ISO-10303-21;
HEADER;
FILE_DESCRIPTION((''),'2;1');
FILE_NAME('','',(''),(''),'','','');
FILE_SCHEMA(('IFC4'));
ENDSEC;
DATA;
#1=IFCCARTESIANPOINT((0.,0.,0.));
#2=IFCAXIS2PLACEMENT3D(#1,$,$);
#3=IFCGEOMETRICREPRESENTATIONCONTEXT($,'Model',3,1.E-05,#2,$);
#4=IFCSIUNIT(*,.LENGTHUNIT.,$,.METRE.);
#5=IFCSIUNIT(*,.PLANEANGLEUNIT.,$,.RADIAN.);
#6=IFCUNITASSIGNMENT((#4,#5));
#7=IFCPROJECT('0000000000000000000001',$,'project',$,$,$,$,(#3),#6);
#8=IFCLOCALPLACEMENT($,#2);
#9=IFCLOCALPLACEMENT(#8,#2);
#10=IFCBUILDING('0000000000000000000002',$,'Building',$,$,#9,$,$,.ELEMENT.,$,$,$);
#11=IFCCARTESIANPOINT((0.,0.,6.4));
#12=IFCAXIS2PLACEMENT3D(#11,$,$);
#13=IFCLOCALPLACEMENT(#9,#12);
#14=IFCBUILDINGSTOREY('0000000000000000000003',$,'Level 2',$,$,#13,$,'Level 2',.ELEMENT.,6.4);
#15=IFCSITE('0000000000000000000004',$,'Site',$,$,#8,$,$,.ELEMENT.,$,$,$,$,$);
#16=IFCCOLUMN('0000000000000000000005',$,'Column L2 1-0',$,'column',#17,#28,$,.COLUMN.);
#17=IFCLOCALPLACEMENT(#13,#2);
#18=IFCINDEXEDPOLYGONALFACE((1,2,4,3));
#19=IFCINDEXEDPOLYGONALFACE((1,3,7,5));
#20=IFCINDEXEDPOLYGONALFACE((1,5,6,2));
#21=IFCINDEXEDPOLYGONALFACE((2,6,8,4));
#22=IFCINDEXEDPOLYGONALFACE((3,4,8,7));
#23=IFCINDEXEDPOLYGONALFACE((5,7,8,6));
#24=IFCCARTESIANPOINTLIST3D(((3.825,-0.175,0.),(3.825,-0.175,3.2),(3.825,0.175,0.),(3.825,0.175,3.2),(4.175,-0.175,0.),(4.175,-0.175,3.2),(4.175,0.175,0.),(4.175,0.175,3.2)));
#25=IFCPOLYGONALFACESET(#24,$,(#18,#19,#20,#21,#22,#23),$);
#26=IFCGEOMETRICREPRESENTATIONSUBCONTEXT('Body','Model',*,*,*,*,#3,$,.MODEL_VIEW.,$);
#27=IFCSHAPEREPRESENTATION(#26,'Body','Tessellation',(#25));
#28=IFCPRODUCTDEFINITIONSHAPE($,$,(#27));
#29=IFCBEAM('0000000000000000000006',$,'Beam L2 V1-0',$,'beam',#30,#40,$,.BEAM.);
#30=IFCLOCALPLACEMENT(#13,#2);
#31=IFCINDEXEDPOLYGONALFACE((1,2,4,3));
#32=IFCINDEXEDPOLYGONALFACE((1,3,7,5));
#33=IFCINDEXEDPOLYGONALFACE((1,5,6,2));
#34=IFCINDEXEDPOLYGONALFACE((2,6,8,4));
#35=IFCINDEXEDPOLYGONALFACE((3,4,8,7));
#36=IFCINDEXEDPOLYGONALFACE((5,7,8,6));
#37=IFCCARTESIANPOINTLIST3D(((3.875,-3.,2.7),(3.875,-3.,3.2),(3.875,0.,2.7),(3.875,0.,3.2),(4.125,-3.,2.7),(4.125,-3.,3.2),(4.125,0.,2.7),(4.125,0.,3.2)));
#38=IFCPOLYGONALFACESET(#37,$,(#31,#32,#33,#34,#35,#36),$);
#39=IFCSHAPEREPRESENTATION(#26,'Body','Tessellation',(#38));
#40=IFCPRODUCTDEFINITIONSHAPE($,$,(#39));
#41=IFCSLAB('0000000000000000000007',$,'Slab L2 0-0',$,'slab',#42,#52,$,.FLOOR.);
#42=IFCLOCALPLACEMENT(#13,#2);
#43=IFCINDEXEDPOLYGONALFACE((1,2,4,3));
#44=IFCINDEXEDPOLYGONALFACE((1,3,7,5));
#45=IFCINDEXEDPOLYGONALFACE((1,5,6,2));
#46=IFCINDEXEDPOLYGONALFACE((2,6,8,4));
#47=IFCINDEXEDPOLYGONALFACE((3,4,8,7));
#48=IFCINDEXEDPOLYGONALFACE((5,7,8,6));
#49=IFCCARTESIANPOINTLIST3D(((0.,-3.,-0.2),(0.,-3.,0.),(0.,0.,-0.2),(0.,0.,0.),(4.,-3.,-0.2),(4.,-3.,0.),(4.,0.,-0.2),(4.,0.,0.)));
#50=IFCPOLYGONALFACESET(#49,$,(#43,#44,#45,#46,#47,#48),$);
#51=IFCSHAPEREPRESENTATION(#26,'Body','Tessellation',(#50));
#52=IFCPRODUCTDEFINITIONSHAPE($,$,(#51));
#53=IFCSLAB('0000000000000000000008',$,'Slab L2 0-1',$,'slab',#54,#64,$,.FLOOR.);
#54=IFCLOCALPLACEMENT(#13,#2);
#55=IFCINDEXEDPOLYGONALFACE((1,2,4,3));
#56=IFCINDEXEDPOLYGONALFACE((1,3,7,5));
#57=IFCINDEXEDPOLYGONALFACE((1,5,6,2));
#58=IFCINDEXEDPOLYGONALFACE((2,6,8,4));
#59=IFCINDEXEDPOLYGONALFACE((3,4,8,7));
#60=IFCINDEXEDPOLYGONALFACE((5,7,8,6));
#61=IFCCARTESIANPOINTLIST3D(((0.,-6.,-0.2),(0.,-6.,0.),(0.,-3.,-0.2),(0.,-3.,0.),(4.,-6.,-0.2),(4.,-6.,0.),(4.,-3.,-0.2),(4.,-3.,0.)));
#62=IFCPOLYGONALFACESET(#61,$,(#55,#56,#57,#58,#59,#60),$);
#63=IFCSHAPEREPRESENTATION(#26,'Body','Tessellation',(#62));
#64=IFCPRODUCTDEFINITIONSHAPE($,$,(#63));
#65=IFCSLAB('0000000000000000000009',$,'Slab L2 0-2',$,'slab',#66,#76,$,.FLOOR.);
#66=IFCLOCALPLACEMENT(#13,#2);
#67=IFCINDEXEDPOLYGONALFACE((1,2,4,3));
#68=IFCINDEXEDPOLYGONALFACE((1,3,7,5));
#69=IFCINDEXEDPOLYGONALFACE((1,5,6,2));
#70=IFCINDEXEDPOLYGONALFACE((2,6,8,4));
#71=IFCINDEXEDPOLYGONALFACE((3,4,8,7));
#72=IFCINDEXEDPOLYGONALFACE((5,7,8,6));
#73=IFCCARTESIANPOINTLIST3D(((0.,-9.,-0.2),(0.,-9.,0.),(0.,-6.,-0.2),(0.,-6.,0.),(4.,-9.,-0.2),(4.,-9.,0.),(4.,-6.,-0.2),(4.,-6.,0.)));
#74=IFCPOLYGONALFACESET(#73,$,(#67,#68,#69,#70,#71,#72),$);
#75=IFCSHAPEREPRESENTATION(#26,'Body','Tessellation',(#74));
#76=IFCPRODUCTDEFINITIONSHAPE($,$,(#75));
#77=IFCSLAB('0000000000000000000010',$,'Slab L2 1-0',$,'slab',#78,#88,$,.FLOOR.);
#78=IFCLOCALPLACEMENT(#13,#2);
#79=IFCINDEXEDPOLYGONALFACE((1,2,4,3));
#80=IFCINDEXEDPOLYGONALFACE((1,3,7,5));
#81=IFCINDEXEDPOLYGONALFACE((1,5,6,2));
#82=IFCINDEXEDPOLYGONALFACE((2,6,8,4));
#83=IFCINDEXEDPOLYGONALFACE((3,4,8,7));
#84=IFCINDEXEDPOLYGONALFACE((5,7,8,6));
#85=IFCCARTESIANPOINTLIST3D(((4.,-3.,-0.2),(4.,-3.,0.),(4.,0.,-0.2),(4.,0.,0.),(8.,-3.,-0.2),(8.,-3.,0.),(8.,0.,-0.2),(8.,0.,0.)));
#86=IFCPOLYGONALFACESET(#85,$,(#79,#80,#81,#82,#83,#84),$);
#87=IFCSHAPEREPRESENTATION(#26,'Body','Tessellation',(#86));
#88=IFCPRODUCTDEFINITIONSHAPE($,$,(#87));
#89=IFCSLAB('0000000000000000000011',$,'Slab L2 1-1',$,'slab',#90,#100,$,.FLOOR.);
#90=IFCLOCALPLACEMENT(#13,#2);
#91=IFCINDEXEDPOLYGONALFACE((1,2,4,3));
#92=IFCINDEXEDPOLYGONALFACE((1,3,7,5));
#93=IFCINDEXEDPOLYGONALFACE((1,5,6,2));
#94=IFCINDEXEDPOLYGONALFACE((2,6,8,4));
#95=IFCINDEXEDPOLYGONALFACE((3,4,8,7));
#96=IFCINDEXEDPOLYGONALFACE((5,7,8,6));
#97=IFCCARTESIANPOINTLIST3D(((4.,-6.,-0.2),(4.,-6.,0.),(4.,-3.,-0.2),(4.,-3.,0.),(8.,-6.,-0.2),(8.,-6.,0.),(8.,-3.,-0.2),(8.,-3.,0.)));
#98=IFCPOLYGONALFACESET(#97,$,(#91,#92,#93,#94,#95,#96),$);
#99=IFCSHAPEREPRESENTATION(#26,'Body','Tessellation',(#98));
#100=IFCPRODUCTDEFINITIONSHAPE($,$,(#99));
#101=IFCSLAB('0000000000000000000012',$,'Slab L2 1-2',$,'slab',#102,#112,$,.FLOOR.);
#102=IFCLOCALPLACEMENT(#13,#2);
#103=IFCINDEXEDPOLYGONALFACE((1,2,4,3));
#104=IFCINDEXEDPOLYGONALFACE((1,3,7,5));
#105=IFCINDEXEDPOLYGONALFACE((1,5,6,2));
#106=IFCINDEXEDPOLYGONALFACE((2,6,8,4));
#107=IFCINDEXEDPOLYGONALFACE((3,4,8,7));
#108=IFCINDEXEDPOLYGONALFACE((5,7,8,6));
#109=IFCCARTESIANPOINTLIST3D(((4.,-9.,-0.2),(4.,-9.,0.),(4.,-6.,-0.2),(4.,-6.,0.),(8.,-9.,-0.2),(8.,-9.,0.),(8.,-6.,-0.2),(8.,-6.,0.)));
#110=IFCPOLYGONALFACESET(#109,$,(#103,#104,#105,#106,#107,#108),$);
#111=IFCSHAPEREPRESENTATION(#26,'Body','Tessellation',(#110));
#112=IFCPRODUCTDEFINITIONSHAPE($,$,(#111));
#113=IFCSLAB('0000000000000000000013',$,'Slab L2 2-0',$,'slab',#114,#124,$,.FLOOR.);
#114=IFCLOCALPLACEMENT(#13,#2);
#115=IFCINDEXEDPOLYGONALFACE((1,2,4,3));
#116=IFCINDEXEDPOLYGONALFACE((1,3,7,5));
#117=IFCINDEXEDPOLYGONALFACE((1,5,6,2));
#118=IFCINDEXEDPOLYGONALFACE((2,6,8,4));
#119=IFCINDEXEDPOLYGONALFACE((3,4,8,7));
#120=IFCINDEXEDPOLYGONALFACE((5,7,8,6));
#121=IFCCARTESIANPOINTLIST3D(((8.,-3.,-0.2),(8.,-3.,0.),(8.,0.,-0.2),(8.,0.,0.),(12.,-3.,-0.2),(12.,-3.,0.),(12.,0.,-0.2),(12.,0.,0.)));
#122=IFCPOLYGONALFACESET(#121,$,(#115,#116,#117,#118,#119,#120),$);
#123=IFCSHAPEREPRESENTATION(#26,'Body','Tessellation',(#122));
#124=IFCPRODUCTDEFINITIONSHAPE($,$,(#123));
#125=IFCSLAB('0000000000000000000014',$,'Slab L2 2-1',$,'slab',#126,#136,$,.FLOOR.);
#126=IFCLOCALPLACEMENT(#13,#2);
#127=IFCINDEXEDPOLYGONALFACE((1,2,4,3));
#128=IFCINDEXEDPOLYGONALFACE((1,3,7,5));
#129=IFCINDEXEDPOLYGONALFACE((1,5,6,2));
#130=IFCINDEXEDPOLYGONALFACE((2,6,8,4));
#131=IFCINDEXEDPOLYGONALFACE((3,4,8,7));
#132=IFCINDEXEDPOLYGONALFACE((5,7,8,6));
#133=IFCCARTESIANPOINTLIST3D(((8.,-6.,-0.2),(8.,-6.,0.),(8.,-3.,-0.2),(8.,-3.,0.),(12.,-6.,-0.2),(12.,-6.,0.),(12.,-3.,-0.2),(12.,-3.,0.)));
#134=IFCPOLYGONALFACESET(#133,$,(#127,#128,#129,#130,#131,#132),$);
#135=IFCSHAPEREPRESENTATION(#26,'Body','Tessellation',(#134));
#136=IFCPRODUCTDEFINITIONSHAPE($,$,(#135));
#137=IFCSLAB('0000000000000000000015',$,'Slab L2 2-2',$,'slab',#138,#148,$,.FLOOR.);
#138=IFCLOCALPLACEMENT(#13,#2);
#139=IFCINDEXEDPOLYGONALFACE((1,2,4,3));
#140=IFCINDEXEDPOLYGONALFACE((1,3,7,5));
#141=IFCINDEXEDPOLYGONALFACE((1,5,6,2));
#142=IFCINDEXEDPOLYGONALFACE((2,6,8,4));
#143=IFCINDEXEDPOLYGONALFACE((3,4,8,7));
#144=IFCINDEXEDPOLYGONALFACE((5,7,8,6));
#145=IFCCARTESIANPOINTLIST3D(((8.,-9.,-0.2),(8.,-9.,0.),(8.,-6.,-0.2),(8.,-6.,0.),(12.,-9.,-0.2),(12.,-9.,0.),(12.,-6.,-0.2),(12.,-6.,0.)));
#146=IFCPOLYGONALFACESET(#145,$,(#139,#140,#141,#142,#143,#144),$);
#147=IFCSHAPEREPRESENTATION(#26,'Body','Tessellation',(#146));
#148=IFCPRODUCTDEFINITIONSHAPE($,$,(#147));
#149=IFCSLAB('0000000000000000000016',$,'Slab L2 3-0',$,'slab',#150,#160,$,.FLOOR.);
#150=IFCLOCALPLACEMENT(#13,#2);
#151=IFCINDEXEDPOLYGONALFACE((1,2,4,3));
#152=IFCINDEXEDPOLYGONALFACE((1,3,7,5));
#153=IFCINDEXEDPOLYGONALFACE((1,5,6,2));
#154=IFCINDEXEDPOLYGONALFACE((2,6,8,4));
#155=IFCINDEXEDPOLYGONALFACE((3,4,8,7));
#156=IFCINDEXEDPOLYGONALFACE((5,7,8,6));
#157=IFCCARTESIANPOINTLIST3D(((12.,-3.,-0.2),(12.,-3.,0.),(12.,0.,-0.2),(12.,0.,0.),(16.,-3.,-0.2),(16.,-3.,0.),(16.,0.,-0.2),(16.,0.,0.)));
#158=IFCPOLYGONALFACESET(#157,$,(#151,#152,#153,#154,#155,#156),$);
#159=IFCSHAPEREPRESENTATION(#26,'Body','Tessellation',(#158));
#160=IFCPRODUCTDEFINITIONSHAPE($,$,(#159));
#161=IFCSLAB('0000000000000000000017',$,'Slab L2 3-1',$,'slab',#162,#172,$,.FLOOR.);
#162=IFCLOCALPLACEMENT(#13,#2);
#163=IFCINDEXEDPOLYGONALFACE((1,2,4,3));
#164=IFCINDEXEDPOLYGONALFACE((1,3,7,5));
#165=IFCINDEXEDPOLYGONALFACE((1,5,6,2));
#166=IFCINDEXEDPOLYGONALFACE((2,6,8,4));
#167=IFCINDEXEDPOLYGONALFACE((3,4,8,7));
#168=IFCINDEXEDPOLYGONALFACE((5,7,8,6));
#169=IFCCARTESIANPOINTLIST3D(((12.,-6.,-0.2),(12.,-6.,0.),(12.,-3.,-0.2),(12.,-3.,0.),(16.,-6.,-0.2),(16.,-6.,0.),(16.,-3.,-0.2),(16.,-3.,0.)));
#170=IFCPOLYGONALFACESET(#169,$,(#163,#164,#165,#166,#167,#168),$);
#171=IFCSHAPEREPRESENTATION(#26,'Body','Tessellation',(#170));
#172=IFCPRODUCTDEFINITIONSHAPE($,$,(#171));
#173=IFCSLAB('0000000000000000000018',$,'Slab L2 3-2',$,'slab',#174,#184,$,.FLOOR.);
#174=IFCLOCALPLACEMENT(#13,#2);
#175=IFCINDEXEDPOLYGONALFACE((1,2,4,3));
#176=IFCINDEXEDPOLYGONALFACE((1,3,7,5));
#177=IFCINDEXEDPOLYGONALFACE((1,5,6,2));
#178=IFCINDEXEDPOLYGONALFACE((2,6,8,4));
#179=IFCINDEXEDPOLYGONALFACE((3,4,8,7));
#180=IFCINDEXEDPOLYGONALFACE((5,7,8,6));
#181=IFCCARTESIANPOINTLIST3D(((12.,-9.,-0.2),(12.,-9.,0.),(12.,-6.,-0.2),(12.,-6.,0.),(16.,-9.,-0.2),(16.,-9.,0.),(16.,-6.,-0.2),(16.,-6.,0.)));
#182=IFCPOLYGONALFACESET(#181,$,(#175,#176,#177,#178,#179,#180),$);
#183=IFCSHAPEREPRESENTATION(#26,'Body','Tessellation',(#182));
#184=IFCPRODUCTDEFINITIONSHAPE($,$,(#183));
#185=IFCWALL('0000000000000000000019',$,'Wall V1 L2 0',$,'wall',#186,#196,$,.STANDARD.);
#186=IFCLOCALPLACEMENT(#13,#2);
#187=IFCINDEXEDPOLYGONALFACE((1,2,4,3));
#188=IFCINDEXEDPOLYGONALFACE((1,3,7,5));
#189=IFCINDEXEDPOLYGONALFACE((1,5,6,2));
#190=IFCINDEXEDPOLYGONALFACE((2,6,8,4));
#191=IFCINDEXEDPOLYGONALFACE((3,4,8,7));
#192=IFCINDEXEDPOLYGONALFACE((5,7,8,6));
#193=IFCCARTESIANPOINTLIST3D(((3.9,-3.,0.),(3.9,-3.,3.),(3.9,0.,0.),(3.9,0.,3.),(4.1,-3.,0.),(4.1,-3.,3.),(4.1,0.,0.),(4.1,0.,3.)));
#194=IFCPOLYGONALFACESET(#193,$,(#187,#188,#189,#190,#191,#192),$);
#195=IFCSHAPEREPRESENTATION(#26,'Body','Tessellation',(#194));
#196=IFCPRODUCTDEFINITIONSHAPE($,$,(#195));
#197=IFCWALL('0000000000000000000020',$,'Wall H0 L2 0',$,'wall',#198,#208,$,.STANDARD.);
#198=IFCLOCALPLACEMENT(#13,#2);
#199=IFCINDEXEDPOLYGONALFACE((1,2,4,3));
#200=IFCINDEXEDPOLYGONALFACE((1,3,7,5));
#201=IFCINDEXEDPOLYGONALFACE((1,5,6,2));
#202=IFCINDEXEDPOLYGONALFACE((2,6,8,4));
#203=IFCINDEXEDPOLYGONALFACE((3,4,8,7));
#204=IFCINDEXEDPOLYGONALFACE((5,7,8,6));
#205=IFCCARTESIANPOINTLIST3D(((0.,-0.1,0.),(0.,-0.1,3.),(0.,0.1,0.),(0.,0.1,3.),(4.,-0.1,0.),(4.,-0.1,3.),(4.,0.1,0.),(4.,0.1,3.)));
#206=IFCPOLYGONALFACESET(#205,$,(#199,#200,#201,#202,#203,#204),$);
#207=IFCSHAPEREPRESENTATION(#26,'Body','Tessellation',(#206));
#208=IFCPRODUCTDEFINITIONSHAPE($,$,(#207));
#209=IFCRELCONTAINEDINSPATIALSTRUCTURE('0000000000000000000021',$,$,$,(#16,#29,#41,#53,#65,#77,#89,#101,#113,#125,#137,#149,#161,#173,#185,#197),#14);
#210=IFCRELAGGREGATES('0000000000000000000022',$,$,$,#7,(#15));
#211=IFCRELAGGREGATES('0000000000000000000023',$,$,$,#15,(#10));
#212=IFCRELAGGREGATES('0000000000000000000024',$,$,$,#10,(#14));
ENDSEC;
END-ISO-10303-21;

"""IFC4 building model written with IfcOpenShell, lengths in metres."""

from ifc_helpers import new_model, si_unit, frame, frame_2d, origin, origin_with_axes, origin_2d, place, context, subcontext, project, spatial, polyline, rectangle, outline, extrude, element, save


model = new_model("IFC4")

# Units and contexts
model_context = context("Model", 3, precision=1e-05, world=origin())
body_context = subcontext(model_context, "Body", "Model", "MODEL_VIEW")
ifc_project = project(units=[si_unit("LENGTHUNIT", "METRE"), si_unit("PLANEANGLEUNIT", "RADIAN")], contexts=[model_context])

# Site, building, storey
site_placement = place(None, origin())
site = spatial("IfcSite", under=ifc_project, at=site_placement, Name="Site", CompositionType="ELEMENT")
building_placement = place(site_placement, origin())
building = spatial("IfcBuilding", under=site, at=building_placement, Name="Building", CompositionType="ELEMENT")
storey_placement = place(building_placement, frame((0.0, 0.0, 6.4)))
storey = spatial("IfcBuildingStorey", under=building, at=storey_placement, Name="Level 2", LongName="Level 2", CompositionType="ELEMENT", Elevation=6.4)

# Column
column_placement = place(storey_placement, frame((4.0, 0.0, 0.0)))
element("IfcColumn", 1, at=column_placement, inside=storey, Name="Column L2 1-0", ObjectType="column", PredefinedType="COLUMN", context=body_context, shape_type="SweptSolid", body=[
    extrude(rectangle(XDim=0.35, YDim=0.35, at=origin_2d()), origin(), (0.0, 0.0, 1.0), 3.2),
])

# Beam
beam_placement = place(storey_placement, frame((4.0, 0.0, 2.95), z_axis=(0.0, -1.0, 0.0), x_axis=(0.0, 0.0, 1.0)))
element("IfcBeam", 2, at=beam_placement, inside=storey, Name="Beam L2 V1-0", ObjectType="beam", PredefinedType="BEAM", context=body_context, shape_type="SweptSolid", body=[
    extrude(rectangle(XDim=0.5, YDim=0.25, at=origin_2d()), origin(), (0.0, 0.0, 1.0), 3.0),
])

# Slabs
slab_1_placement = place(storey_placement, frame((0.0, 0.0, -0.2)))
element("IfcSlab", 3, at=slab_1_placement, inside=storey, Name="Slab L2 0-0", ObjectType="slab", PredefinedType="FLOOR", context=body_context, shape_type="SweptSolid", body=[
    extrude(outline(polyline([(0.0, -3.0), (4.0, -3.0), (4.0, 0.0), (0.0, 0.0), (0.0, -3.0)])), origin(), (0.0, 0.0, 1.0), 0.2),
])
slab_2_placement = place(storey_placement, frame((0.0, 0.0, -0.2)))
element("IfcSlab", 4, at=slab_2_placement, inside=storey, Name="Slab L2 0-1", ObjectType="slab", PredefinedType="FLOOR", context=body_context, shape_type="SweptSolid", body=[
    extrude(outline(polyline([(0.0, -6.0), (4.0, -6.0), (4.0, -3.0), (0.0, -3.0), (0.0, -6.0)])), origin(), (0.0, 0.0, 1.0), 0.2),
])
slab_3_placement = place(storey_placement, frame((0.0, 0.0, -0.2)))
element("IfcSlab", 5, at=slab_3_placement, inside=storey, Name="Slab L2 0-2", ObjectType="slab", PredefinedType="FLOOR", context=body_context, shape_type="SweptSolid", body=[
    extrude(outline(polyline([(0.0, -9.0), (4.0, -9.0), (4.0, -6.0), (0.0, -6.0), (0.0, -9.0)])), origin(), (0.0, 0.0, 1.0), 0.2),
])
slab_4_placement = place(storey_placement, frame((0.0, 0.0, -0.2)))
element("IfcSlab", 6, at=slab_4_placement, inside=storey, Name="Slab L2 1-0", ObjectType="slab", PredefinedType="FLOOR", context=body_context, shape_type="SweptSolid", body=[
    extrude(outline(polyline([(4.0, -3.0), (8.0, -3.0), (8.0, 0.0), (4.0, 0.0), (4.0, -3.0)])), origin(), (0.0, 0.0, 1.0), 0.2),
])
slab_5_placement = place(storey_placement, frame((0.0, 0.0, -0.2)))
element("IfcSlab", 7, at=slab_5_placement, inside=storey, Name="Slab L2 1-1", ObjectType="slab", PredefinedType="FLOOR", context=body_context, shape_type="SweptSolid", body=[
    extrude(outline(polyline([(4.0, -6.0), (8.0, -6.0), (8.0, -3.0), (4.0, -3.0), (4.0, -6.0)])), origin(), (0.0, 0.0, 1.0), 0.2),
])
slab_6_placement = place(storey_placement, frame((0.0, 0.0, -0.2)))
element("IfcSlab", 8, at=slab_6_placement, inside=storey, Name="Slab L2 1-2", ObjectType="slab", PredefinedType="FLOOR", context=body_context, shape_type="SweptSolid", body=[
    extrude(outline(polyline([(4.0, -9.0), (8.0, -9.0), (8.0, -6.0), (4.0, -6.0), (4.0, -9.0)])), origin(), (0.0, 0.0, 1.0), 0.2),
])
slab_7_placement = place(storey_placement, frame((0.0, 0.0, -0.2)))
element("IfcSlab", 9, at=slab_7_placement, inside=storey, Name="Slab L2 2-0", ObjectType="slab", PredefinedType="FLOOR", context=body_context, shape_type="SweptSolid", body=[
    extrude(outline(polyline([(8.0, -3.0), (12.0, -3.0), (12.0, 0.0), (8.0, 0.0), (8.0, -3.0)])), origin(), (0.0, 0.0, 1.0), 0.2),
])
slab_8_placement = place(storey_placement, frame((0.0, 0.0, -0.2)))
element("IfcSlab", 10, at=slab_8_placement, inside=storey, Name="Slab L2 2-1", ObjectType="slab", PredefinedType="FLOOR", context=body_context, shape_type="SweptSolid", body=[
    extrude(outline(polyline([(8.0, -6.0), (12.0, -6.0), (12.0, -3.0), (8.0, -3.0), (8.0, -6.0)])), origin(), (0.0, 0.0, 1.0), 0.2),
])
slab_9_placement = place(storey_placement, frame((0.0, 0.0, -0.2)))
element("IfcSlab", 11, at=slab_9_placement, inside=storey, Name="Slab L2 2-2", ObjectType="slab", PredefinedType="FLOOR", context=body_context, shape_type="SweptSolid", body=[
    extrude(outline(polyline([(8.0, -9.0), (12.0, -9.0), (12.0, -6.0), (8.0, -6.0), (8.0, -9.0)])), origin(), (0.0, 0.0, 1.0), 0.2),
])
slab_10_placement = place(storey_placement, frame((0.0, 0.0, -0.2)))
element("IfcSlab", 12, at=slab_10_placement, inside=storey, Name="Slab L2 3-0", ObjectType="slab", PredefinedType="FLOOR", context=body_context, shape_type="SweptSolid", body=[
    extrude(outline(polyline([(12.0, -3.0), (16.0, -3.0), (16.0, 0.0), (12.0, 0.0), (12.0, -3.0)])), origin(), (0.0, 0.0, 1.0), 0.2),
])
slab_11_placement = place(storey_placement, frame((0.0, 0.0, -0.2)))
element("IfcSlab", 13, at=slab_11_placement, inside=storey, Name="Slab L2 3-1", ObjectType="slab", PredefinedType="FLOOR", context=body_context, shape_type="SweptSolid", body=[
    extrude(outline(polyline([(12.0, -6.0), (16.0, -6.0), (16.0, -3.0), (12.0, -3.0), (12.0, -6.0)])), origin(), (0.0, 0.0, 1.0), 0.2),
])
slab_12_placement = place(storey_placement, frame((0.0, 0.0, -0.2)))
element("IfcSlab", 14, at=slab_12_placement, inside=storey, Name="Slab L2 3-2", ObjectType="slab", PredefinedType="FLOOR", context=body_context, shape_type="SweptSolid", body=[
    extrude(outline(polyline([(12.0, -9.0), (16.0, -9.0), (16.0, -6.0), (12.0, -6.0), (12.0, -9.0)])), origin(), (0.0, 0.0, 1.0), 0.2),
])

# Walls
wall_1_placement = place(storey_placement, frame((4.0, 0.0, 0.0), z_axis=(0.0, 0.0, 1.0), x_axis=(0.0, -1.0, 0.0)))
element("IfcWall", 15, at=wall_1_placement, inside=storey, Name="Wall V1 L2 0", ObjectType="wall", PredefinedType="STANDARD", context=body_context, shape_type="SweptSolid", body=[
    extrude(rectangle(XDim=3.0, YDim=0.2, at=frame_2d((1.5, 0.0))), origin(), (0.0, 0.0, 1.0), 3.0),
])
wall_2_placement = place(storey_placement, origin_with_axes())
element("IfcWall", 16, at=wall_2_placement, inside=storey, Name="Wall H0 L2 0", ObjectType="wall", PredefinedType="STANDARD", context=body_context, shape_type="SweptSolid", body=[
    extrude(rectangle(XDim=4.0, YDim=0.2, at=frame_2d((2.0, 0.0))), origin(), (0.0, 0.0, 1.0), 3.0),
])

save(model, "model.ifc")
